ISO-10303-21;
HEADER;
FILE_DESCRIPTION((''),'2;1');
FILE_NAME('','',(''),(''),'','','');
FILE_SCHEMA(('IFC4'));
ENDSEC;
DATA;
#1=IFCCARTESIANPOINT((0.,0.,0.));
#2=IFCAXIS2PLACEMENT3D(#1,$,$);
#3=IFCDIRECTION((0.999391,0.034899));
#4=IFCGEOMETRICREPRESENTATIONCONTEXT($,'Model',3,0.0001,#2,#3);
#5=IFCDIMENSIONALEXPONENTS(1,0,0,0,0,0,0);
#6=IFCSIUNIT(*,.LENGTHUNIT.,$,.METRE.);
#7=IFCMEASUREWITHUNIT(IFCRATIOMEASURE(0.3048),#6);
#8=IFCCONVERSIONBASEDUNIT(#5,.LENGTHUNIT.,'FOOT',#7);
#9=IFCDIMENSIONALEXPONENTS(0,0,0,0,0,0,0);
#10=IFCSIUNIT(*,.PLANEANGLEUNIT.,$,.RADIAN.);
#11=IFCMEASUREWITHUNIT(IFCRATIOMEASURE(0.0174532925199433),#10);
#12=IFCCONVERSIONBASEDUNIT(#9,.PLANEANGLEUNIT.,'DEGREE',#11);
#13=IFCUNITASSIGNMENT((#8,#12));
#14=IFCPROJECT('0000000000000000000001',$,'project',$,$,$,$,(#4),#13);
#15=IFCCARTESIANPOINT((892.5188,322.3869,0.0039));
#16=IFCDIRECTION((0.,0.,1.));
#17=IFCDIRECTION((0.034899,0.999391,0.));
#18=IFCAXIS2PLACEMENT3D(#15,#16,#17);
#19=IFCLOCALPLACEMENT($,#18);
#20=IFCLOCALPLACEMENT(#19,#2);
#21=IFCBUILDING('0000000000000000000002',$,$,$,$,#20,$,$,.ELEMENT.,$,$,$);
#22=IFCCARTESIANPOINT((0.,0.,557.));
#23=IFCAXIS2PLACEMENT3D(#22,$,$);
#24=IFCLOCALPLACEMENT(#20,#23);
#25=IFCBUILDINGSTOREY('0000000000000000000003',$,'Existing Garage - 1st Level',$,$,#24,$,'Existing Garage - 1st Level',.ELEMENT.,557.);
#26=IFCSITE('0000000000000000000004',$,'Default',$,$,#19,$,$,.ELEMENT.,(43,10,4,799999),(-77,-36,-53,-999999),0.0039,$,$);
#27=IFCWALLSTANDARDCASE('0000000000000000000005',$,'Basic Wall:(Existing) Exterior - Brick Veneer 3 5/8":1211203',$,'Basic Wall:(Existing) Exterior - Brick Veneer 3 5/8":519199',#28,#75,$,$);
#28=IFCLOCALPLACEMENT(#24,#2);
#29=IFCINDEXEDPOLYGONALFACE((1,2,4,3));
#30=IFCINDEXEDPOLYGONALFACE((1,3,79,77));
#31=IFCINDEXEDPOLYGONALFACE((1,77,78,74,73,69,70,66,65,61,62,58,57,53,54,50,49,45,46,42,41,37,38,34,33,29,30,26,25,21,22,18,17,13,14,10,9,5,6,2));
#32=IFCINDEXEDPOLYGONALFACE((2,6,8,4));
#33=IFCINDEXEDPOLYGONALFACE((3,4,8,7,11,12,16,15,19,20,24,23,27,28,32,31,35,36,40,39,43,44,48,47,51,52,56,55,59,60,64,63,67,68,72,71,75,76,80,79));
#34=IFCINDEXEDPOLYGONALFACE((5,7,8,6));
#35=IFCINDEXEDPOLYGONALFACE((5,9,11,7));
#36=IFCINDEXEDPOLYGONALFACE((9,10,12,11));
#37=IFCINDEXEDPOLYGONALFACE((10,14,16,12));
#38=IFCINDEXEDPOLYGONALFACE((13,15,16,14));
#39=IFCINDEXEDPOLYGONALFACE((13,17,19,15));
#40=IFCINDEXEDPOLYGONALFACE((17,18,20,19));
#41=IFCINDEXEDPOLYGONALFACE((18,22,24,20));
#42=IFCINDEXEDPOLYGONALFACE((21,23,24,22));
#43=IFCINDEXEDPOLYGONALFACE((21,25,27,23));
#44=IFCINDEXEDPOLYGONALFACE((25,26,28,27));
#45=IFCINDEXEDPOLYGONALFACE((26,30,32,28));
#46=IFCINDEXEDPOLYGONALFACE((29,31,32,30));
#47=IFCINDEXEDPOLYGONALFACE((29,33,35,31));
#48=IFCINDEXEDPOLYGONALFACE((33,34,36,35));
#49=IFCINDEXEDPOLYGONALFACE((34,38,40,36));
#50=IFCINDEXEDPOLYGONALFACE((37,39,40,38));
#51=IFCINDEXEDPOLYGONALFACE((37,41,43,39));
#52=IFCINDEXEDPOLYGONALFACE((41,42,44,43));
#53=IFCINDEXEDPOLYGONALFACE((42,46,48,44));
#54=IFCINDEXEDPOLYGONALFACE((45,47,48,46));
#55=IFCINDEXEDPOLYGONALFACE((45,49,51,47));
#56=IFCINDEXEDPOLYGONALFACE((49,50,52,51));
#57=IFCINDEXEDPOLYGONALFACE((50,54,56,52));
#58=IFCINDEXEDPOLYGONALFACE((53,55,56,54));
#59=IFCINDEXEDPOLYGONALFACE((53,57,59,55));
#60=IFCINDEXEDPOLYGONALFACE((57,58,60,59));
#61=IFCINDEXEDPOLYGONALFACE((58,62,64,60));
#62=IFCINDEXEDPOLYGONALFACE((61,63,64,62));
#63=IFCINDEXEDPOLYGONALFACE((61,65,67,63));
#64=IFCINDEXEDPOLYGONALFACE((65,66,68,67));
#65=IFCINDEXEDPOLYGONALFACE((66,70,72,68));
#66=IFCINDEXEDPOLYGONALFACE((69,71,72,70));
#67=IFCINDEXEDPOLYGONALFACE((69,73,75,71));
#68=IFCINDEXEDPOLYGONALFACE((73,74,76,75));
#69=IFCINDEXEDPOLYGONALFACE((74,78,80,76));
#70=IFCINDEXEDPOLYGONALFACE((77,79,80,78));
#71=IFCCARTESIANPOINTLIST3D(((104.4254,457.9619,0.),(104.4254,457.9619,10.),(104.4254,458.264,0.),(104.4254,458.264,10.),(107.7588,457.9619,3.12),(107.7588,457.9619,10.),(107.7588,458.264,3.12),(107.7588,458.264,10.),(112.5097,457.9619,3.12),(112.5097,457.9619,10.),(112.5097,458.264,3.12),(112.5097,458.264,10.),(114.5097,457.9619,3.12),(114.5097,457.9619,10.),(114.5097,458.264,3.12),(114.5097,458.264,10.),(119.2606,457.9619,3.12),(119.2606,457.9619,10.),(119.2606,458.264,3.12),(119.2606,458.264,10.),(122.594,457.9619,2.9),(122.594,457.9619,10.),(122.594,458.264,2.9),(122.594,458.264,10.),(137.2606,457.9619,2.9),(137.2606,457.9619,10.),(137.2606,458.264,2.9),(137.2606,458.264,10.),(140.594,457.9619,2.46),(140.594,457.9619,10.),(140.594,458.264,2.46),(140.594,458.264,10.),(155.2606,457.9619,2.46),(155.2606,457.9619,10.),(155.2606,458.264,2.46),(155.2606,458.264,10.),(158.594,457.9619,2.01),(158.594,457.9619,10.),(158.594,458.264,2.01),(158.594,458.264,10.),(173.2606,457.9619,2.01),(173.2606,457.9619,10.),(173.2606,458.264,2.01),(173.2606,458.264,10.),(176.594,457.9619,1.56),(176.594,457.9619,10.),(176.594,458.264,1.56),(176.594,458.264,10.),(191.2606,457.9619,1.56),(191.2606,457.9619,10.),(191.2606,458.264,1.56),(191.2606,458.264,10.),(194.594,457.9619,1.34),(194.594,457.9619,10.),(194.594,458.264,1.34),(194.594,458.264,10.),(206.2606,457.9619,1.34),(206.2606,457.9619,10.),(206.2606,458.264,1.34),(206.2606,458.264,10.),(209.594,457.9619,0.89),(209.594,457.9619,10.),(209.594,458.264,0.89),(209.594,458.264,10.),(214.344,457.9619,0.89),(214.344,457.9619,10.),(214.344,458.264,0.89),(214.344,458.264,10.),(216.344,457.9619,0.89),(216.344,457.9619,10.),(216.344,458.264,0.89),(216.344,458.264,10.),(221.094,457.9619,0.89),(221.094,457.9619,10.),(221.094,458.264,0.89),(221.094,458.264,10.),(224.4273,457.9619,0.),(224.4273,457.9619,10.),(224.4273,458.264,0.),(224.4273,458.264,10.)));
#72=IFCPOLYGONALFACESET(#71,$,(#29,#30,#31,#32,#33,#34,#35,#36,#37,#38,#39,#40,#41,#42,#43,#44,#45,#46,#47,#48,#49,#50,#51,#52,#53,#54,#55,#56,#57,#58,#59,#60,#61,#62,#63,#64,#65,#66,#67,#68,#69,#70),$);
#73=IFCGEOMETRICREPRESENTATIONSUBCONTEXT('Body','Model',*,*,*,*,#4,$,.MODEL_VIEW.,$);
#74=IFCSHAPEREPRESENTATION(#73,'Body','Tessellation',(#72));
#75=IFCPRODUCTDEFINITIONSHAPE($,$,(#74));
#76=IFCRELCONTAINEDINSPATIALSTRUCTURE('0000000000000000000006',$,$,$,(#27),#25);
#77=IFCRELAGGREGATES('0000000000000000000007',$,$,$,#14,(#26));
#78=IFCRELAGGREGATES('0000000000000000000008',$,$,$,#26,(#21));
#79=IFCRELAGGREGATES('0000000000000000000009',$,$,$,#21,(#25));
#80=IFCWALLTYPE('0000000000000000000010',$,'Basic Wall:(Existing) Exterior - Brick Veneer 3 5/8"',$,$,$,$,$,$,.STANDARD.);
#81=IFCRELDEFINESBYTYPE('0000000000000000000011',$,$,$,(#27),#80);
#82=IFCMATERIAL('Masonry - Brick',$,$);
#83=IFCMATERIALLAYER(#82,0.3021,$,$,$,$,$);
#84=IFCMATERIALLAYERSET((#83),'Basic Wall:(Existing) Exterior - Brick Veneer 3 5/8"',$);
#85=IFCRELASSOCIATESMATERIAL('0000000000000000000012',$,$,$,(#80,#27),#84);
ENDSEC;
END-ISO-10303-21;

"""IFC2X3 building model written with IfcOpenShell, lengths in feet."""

from ifc_helpers import new_model, entity, si_unit, converted_unit, direction, frame, frame_2d, origin, place, context, subcontext, project, spatial, rectangle, extrude, material, layer, layer_set, layer_usage, type_object, element, save


model = new_model("IFC2X3")

# Units and contexts
model_context = context("Model", 3, precision=0.0001, world=origin(), true_north=direction((0.999391, 0.034899)))
body_context = subcontext(model_context, "Body", "Model", "MODEL_VIEW")
ifc_project = project(units=[converted_unit("LENGTHUNIT", "FOOT", entity("IfcRatioMeasure", 0.3048), si_unit("LENGTHUNIT", "METRE"), dimensions=[1, 0, 0, 0, 0, 0, 0]), converted_unit("PLANEANGLEUNIT", "DEGREE", entity("IfcRatioMeasure", 0.0174532925199433), si_unit("PLANEANGLEUNIT", "RADIAN"), dimensions=[0, 0, 0, 0, 0, 0, 0])], contexts=[model_context])

# Site, building, storey
site_placement = place(None, frame((892.5188, 322.3869, 0.0039), z_axis=(0.0, 0.0, 1.0), x_axis=(0.034899, 0.999391, 0.0)))
site = spatial("IfcSite", under=ifc_project, at=site_placement, Name="Default", CompositionType="ELEMENT", RefLatitude=(43, 10, 4, 799999), RefLongitude=(-77, -36, -53, -999999), RefElevation=0.0039)
building_placement = place(site_placement, origin())
building = spatial("IfcBuilding", under=site, at=building_placement, CompositionType="ELEMENT")
storey_placement = place(building_placement, frame((0.0, 0.0, 557.0)))
storey = spatial("IfcBuildingStorey", under=building, at=storey_placement, Name="Existing Garage - 1st Level", LongName="Existing Garage - 1st Level", CompositionType="ELEMENT", Elevation=557.0)

# Wall, openings
ifc_material_1 = material(Name="Masonry - Brick")
ifc_layer = layer(ifc_material_1, 0.3021)
ifc_layer_set = layer_set([ifc_layer], Name="Basic Wall:(Existing) Exterior - Brick Veneer 3 5/8\"")
ifc_layer_usage = layer_usage(ifc_layer_set, "AXIS2", "NEGATIVE", 0.151)
wall_type = type_object("IfcWallType", Name="Basic Wall:(Existing) Exterior - Brick Veneer 3 5/8\"", PredefinedType="STANDARD", material=ifc_layer_set)
wall_placement = place(storey_placement, frame((104.4254, 458.1129, 0.0)))
wall = element("IfcWallStandardCase", 1, at=wall_placement, inside=storey, type_object=wall_type, material=ifc_layer_usage, Name="Basic Wall:(Existing) Exterior - Brick Veneer 3 5/8\":1211203", ObjectType="Basic Wall:(Existing) Exterior - Brick Veneer 3 5/8\":519199", context=body_context, shape_type="SweptSolid", body=[
    extrude(rectangle(XDim=120.0019, YDim=0.3021, at=frame_2d((60.0009, 0.0), x_axis=(-1.0, 0.0))), origin(), (0.0, 0.0, 1.0), 10.0),
])
opening_1_placement = place(wall_placement, origin())
element("IfcOpeningElement", 2, at=opening_1_placement, cuts=wall, ObjectType="Opening", context=body_context, shape_type="SweptSolid", body=[
    extrude(rectangle(XDim=9.11, YDim=4.75, at=frame_2d((0.0, 0.0), x_axis=(0.0, 1.0))), frame((114.2935, 0.151, 5.445), z_axis=(0.0, -1.0, 0.0), x_axis=(-1.0, 0.0, 0.0)), (0.0, 0.0, 1.0), 0.3021),
])
opening_2_placement = place(wall_placement, origin())
element("IfcOpeningElement", 3, at=opening_2_placement, cuts=wall, ObjectType="Opening", context=body_context, shape_type="SweptSolid", body=[
    extrude(rectangle(XDim=9.11, YDim=4.75, at=frame_2d((0.0, 0.0), x_axis=(0.0, 1.0))), frame((107.5435, 0.151, 5.445), z_axis=(0.0, -1.0, 0.0), x_axis=(-1.0, 0.0, 0.0)), (0.0, 0.0, 1.0), 0.3021),
])
opening_3_placement = place(wall_placement, origin())
element("IfcOpeningElement", 4, at=opening_3_placement, cuts=wall, ObjectType="Opening", context=body_context, shape_type="SweptSolid", body=[
    extrude(rectangle(XDim=8.66, YDim=11.6667, at=frame_2d((0.0, 0.0), x_axis=(0.0, 1.0))), frame((96.0019, 0.151, 5.67), z_axis=(0.0, -1.0, 0.0), x_axis=(-1.0, 0.0, 0.0)), (0.0, 0.0, 1.0), 0.3021),
])
opening_4_placement = place(wall_placement, origin())
element("IfcOpeningElement", 5, at=opening_4_placement, cuts=wall, ObjectType="Opening", context=body_context, shape_type="SweptSolid", body=[
    extrude(rectangle(XDim=8.44, YDim=14.6667, at=frame_2d((0.0, 0.0), x_axis=(0.0, 1.0))), frame((79.5019, 0.151, 5.78), z_axis=(0.0, -1.0, 0.0), x_axis=(-1.0, 0.0, 0.0)), (0.0, 0.0, 1.0), 0.3021),
])
opening_5_placement = place(wall_placement, origin())
element("IfcOpeningElement", 6, at=opening_5_placement, cuts=wall, ObjectType="Opening", context=body_context, shape_type="SweptSolid", body=[
    extrude(rectangle(XDim=7.99, YDim=14.6667, at=frame_2d((0.0, 0.0), x_axis=(0.0, 1.0))), frame((61.5019, 0.151, 6.005), z_axis=(0.0, -1.0, 0.0), x_axis=(-1.0, 0.0, 0.0)), (0.0, 0.0, 1.0), 0.3021),
])
opening_6_placement = place(wall_placement, origin())
element("IfcOpeningElement", 7, at=opening_6_placement, cuts=wall, ObjectType="Opening", context=body_context, shape_type="SweptSolid", body=[
    extrude(rectangle(XDim=7.54, YDim=14.6667, at=frame_2d((0.0, 0.0), x_axis=(0.0, 1.0))), frame((43.5019, 0.151, 6.23), z_axis=(0.0, -1.0, 0.0), x_axis=(-1.0, 0.0, 0.0)), (0.0, 0.0, 1.0), 0.3021),
])
opening_7_placement = place(wall_placement, origin())
element("IfcOpeningElement", 8, at=opening_7_placement, cuts=wall, ObjectType="Opening", context=body_context, shape_type="SweptSolid", body=[
    extrude(rectangle(XDim=7.1, YDim=14.6667, at=frame_2d((0.0, 0.0), x_axis=(0.0, 1.0))), frame((25.5019, 0.151, 6.45), z_axis=(0.0, -1.0, 0.0), x_axis=(-1.0, 0.0, 0.0)), (0.0, 0.0, 1.0), 0.3021),
])
opening_8_placement = place(wall_placement, origin())
element("IfcOpeningElement", 9, at=opening_8_placement, cuts=wall, ObjectType="Opening", context=body_context, shape_type="SweptSolid", body=[
    extrude(rectangle(XDim=6.88, YDim=4.7509, at=frame_2d((0.0, 0.0), x_axis=(0.0, 1.0))), frame((12.4597, 0.151, 6.56), z_axis=(0.0, -1.0, 0.0), x_axis=(-1.0, 0.0, 0.0)), (0.0, 0.0, 1.0), 0.3021),
])
opening_9_placement = place(wall_placement, origin())
element("IfcOpeningElement", 10, at=opening_9_placement, cuts=wall, ObjectType="Opening", context=body_context, shape_type="SweptSolid", body=[
    extrude(rectangle(XDim=6.88, YDim=4.7509, at=frame_2d((0.0, 0.0), x_axis=(0.0, 1.0))), frame((5.7088, 0.151, 6.56), z_axis=(0.0, -1.0, 0.0), x_axis=(-1.0, 0.0, 0.0)), (0.0, 0.0, 1.0), 0.3021),
])

save(model, "model.ifc")
